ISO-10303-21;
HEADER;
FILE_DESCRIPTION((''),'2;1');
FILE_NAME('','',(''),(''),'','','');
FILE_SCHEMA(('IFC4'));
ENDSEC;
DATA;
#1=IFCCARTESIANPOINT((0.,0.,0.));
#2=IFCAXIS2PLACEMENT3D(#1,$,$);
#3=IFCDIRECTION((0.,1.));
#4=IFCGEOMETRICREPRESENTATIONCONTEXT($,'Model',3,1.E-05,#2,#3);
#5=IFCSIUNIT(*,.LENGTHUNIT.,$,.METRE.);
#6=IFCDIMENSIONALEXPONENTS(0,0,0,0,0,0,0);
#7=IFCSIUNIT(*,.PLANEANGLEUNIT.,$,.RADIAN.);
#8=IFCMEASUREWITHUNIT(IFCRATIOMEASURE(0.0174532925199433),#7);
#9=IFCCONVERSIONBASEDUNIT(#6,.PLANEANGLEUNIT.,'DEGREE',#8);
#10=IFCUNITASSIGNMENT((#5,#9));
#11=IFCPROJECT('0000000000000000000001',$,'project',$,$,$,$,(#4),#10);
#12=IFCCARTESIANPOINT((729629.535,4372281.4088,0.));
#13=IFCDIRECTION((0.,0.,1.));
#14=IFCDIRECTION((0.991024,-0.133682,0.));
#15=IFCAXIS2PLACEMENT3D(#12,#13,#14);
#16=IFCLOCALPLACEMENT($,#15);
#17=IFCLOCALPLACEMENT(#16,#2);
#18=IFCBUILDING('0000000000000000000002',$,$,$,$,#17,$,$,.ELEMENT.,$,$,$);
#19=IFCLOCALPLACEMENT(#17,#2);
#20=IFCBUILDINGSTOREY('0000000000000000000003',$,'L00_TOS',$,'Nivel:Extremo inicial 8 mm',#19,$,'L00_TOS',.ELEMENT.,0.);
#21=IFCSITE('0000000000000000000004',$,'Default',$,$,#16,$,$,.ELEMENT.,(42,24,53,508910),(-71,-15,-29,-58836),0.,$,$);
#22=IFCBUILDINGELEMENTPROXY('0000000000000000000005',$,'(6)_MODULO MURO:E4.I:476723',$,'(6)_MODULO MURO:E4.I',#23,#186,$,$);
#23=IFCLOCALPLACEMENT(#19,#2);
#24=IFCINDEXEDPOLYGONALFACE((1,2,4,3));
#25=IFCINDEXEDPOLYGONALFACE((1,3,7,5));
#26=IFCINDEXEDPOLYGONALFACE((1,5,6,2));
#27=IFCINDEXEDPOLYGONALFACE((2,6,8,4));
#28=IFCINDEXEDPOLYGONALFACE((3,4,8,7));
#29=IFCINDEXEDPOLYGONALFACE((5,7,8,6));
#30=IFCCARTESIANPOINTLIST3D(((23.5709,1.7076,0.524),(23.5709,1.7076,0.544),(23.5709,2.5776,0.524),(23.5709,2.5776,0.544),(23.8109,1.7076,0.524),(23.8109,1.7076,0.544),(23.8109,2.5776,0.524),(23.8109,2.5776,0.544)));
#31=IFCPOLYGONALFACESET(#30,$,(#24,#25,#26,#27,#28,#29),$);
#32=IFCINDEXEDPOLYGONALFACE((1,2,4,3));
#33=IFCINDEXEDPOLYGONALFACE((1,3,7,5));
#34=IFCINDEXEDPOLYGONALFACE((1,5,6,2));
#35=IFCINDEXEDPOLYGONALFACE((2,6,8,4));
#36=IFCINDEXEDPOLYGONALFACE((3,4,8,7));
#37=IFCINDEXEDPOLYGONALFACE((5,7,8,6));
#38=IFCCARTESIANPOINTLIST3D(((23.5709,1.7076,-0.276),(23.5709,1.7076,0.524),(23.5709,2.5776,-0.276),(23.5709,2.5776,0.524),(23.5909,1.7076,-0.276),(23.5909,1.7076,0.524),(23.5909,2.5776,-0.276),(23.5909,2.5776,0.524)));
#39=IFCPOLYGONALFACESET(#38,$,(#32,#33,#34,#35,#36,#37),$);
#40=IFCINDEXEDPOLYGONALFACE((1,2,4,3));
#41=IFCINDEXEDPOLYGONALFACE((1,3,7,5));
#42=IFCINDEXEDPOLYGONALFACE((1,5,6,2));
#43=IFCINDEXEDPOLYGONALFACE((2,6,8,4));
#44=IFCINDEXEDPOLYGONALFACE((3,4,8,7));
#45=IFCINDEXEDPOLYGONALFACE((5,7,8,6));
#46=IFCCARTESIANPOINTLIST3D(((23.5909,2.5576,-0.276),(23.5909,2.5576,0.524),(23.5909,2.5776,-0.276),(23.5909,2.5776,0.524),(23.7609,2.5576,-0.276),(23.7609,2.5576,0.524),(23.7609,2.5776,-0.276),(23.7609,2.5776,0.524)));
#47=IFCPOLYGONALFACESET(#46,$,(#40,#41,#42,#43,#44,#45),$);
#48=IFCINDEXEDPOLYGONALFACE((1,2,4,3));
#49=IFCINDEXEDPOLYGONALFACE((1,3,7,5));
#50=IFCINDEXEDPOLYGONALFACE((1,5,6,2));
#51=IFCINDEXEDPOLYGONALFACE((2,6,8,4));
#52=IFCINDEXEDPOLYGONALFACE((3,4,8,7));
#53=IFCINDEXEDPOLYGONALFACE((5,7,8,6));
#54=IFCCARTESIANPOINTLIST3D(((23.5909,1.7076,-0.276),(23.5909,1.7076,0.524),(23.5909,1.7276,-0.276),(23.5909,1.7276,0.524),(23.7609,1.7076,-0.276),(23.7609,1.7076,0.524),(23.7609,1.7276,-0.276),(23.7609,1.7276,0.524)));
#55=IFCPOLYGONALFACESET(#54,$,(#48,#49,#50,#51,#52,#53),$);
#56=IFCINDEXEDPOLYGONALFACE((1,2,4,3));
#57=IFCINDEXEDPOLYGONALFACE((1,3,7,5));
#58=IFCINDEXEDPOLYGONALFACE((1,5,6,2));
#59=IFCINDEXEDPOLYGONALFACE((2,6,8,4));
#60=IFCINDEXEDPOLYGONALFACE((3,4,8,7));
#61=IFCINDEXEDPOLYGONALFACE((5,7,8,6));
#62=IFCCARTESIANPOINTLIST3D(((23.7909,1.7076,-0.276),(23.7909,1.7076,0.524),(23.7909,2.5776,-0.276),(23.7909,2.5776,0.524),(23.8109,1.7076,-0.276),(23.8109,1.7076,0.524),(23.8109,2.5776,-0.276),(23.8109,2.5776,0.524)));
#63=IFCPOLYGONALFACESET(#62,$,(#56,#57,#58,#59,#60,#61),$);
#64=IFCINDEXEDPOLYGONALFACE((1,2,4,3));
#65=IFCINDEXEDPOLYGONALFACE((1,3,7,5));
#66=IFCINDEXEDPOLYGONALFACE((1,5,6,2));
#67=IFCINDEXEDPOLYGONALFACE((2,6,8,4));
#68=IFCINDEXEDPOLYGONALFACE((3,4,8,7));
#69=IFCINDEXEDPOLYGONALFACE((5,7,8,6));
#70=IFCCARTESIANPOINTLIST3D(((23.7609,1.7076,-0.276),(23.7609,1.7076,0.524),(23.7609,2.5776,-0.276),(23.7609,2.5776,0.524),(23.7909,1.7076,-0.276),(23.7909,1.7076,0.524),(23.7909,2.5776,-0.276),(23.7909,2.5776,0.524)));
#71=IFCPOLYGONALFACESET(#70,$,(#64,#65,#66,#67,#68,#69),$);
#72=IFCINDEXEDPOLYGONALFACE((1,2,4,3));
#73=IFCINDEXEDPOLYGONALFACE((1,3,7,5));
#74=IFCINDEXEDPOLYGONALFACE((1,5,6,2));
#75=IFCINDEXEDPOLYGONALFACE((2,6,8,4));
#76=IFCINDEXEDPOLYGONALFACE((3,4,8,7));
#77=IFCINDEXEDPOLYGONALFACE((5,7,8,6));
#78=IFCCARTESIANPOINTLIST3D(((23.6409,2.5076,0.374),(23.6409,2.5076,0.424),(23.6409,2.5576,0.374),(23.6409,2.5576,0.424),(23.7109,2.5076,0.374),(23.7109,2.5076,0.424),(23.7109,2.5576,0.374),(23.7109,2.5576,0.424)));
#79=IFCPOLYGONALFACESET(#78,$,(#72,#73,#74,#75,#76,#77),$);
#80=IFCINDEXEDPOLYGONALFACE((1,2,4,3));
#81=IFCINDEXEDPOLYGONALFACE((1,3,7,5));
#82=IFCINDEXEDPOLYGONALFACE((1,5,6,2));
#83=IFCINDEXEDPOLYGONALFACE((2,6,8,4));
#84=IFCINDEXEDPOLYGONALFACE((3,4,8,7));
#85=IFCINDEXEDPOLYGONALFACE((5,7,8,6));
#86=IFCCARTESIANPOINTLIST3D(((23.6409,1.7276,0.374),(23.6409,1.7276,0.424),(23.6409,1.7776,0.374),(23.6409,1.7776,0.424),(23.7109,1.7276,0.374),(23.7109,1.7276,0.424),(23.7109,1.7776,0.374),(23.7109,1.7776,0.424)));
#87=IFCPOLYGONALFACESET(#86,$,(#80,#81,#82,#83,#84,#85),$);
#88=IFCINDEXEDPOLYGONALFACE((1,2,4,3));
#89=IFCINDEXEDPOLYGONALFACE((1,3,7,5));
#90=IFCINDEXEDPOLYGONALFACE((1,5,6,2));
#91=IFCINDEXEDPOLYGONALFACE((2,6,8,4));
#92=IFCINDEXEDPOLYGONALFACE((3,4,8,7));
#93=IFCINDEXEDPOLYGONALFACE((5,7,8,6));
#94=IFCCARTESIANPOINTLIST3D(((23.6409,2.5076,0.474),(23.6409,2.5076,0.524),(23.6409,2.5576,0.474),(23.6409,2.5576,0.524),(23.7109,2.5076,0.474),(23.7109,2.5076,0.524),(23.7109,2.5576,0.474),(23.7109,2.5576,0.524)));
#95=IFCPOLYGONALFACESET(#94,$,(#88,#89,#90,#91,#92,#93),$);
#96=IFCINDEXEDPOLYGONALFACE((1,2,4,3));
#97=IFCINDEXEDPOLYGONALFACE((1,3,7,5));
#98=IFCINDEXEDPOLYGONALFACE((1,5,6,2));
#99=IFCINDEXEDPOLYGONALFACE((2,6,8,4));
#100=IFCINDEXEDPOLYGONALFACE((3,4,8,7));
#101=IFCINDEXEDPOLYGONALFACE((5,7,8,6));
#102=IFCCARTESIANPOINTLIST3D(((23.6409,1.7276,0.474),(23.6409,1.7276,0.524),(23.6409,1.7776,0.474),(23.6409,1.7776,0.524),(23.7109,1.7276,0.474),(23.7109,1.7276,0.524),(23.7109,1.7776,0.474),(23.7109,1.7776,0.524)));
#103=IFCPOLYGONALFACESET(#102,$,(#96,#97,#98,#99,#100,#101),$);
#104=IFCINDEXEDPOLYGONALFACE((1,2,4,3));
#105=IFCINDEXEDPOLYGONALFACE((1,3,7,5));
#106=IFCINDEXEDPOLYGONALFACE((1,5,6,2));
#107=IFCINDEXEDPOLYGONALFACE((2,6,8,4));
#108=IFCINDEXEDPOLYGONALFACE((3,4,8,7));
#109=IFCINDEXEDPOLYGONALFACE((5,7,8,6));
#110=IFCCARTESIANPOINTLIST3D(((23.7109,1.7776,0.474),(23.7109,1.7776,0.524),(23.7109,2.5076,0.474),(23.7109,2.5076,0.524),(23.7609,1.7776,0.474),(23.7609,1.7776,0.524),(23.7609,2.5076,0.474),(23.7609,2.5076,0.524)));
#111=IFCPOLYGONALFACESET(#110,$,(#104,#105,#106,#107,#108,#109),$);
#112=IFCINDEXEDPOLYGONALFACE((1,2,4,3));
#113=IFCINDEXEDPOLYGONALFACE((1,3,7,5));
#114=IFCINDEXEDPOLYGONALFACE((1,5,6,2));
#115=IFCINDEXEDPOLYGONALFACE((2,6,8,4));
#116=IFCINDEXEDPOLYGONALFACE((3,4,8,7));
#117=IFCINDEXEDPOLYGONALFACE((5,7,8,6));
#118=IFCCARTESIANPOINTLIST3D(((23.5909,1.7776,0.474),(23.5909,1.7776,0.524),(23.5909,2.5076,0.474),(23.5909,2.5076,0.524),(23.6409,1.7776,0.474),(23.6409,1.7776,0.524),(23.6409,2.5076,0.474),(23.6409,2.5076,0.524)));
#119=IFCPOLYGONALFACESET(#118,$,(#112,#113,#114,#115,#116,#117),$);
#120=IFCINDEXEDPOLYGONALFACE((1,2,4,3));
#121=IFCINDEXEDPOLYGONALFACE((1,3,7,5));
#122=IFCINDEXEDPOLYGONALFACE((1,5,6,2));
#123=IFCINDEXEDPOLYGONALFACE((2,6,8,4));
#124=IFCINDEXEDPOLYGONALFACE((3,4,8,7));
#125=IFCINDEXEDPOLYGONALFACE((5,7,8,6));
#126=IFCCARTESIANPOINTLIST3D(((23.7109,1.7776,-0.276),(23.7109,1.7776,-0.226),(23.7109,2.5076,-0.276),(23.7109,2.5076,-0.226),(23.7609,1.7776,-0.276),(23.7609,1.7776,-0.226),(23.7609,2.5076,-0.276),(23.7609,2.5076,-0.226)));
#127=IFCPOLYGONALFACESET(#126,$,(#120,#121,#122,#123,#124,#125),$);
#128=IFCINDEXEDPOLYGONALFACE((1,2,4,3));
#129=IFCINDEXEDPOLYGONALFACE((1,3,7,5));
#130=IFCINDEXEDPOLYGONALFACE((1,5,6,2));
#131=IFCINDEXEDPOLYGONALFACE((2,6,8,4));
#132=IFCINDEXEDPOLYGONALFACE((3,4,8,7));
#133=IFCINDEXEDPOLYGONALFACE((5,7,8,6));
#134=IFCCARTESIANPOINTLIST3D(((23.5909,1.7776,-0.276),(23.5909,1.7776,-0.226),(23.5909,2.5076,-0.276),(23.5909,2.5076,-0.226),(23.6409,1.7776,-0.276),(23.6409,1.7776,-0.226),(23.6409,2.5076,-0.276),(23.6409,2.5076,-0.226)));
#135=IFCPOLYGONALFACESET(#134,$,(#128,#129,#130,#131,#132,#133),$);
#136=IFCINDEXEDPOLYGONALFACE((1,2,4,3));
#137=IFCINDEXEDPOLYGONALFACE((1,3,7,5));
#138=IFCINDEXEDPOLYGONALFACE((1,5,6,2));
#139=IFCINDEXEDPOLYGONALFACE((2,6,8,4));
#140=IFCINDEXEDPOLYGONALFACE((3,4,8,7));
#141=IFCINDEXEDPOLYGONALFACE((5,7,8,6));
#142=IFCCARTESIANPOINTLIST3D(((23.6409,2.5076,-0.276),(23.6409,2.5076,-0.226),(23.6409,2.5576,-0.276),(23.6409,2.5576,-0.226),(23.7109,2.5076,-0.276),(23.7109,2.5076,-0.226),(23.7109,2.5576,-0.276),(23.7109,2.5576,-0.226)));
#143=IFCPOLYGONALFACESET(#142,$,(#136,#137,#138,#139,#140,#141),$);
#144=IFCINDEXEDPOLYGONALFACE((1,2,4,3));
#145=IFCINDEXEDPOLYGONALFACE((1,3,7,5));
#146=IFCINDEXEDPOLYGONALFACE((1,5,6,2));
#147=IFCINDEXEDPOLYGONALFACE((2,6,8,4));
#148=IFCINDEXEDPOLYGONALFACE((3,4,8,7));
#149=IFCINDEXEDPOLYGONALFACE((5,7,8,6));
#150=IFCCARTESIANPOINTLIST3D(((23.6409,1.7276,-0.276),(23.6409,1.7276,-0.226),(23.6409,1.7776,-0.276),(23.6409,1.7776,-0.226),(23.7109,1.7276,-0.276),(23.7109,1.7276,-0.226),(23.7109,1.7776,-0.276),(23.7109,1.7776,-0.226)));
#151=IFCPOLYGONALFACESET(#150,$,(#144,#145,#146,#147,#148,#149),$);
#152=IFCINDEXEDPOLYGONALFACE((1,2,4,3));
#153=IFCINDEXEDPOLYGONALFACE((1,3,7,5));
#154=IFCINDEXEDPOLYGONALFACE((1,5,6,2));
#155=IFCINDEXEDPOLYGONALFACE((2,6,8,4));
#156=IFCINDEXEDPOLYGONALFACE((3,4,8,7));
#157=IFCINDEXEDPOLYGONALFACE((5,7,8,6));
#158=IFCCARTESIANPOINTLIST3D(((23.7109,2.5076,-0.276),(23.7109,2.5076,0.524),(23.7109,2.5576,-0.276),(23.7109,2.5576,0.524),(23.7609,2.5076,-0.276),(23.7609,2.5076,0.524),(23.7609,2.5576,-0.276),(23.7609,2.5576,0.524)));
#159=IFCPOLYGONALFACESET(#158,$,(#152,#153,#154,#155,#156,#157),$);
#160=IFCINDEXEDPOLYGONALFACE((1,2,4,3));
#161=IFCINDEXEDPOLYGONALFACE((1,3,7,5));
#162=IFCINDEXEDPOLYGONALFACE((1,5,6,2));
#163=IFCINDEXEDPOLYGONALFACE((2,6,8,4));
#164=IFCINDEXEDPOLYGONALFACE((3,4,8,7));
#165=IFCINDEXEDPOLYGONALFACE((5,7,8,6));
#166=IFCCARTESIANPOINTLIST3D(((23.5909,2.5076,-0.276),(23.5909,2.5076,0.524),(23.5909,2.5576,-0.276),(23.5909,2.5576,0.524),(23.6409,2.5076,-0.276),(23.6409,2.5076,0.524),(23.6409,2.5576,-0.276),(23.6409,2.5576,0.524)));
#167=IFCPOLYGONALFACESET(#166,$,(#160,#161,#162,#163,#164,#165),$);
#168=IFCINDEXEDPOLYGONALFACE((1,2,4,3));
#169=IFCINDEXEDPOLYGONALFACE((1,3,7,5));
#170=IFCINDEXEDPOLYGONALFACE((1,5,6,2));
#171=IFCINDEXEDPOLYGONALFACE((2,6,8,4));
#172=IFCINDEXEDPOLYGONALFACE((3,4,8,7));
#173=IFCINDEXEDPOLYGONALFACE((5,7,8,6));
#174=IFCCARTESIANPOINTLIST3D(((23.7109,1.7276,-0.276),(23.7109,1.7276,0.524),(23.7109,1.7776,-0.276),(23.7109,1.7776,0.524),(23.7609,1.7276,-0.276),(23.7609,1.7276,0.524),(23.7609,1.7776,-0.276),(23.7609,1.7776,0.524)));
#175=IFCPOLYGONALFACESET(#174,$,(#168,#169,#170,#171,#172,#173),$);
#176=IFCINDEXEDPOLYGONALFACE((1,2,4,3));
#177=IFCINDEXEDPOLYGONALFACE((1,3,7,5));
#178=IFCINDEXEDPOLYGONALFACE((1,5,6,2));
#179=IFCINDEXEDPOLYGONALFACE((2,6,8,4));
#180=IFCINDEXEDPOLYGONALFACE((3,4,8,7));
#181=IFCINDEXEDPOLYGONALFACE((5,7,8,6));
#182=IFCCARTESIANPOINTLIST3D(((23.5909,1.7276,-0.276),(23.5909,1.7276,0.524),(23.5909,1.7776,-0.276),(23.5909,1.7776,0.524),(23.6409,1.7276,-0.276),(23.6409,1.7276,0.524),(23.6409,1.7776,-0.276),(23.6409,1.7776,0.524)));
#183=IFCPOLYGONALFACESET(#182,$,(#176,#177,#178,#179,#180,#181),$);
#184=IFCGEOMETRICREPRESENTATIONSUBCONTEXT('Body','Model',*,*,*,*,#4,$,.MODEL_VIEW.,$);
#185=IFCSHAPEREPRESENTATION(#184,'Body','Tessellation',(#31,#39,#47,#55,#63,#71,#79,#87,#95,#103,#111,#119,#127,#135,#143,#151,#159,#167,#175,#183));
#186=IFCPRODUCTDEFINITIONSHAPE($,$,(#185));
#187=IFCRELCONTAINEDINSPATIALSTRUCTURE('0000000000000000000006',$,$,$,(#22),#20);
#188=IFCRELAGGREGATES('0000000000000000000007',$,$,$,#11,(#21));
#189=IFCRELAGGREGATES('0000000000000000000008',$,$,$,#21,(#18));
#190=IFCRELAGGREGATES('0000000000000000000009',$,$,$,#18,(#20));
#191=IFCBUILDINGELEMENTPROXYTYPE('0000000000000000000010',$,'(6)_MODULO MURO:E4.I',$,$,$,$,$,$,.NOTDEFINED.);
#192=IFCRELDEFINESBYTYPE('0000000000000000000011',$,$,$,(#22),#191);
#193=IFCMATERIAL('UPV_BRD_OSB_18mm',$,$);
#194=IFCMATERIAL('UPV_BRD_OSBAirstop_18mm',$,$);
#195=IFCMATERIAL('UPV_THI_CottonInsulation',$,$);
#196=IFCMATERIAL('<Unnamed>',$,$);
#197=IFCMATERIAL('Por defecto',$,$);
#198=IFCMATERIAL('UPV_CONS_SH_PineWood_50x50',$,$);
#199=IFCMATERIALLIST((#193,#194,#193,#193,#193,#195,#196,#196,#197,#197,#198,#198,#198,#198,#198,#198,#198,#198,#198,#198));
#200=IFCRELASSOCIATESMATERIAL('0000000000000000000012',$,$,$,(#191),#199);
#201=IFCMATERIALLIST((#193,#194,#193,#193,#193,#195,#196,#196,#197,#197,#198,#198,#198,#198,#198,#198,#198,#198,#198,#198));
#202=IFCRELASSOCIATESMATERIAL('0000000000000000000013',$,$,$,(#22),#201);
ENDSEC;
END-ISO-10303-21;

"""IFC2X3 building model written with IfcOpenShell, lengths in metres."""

from ifc_helpers import new_model, entity, si_unit, converted_unit, direction, frame, frame_2d, origin, origin_2d_with_axis, place, context, subcontext, project, spatial, rectangle, extrude, source, transform, mapped, material, material_list, type_object, type_shapes, element, save


model = new_model("IFC2X3")

# Units and contexts
model_context = context("Model", 3, precision=1e-05, world=origin(), true_north=direction((0.0, 1.0)))
body_context = subcontext(model_context, "Body", "Model", "MODEL_VIEW")
ifc_project = project(units=[si_unit("LENGTHUNIT", "METRE"), converted_unit("PLANEANGLEUNIT", "DEGREE", entity("IfcRatioMeasure", 0.0174532925199433), si_unit("PLANEANGLEUNIT", "RADIAN"), dimensions=[0, 0, 0, 0, 0, 0, 0])], contexts=[model_context])

# Site, building, storey
site_placement = place(None, frame((729629.535, 4372281.4088, 0.0), z_axis=(0.0, 0.0, 1.0), x_axis=(0.991024, -0.133682, 0.0)))
site = spatial("IfcSite", under=ifc_project, at=site_placement, Name="Default", CompositionType="ELEMENT", RefLatitude=(42, 24, 53, 508910), RefLongitude=(-71, -15, -29, -58836), RefElevation=0.0)
building_placement = place(site_placement, origin())
building = spatial("IfcBuilding", under=site, at=building_placement, CompositionType="ELEMENT")
storey_placement = place(building_placement, origin())
storey = spatial("IfcBuildingStorey", under=building, at=storey_placement, Name="L00_TOS", ObjectType="Nivel:Extremo inicial 8 mm", LongName="L00_TOS", CompositionType="ELEMENT", Elevation=0.0)

# Building element proxy
ifc_material_1 = material(Name="UPV_BRD_OSBAirstop_18mm")
ifc_material_2 = material(Name="UPV_BRD_OSB_18mm")
ifc_material_3 = material(Name="UPV_THI_CottonInsulation")
ifc_material_4 = material(Name="<Unnamed>")
ifc_material_5 = material(Name="UPV_CONS_SH_PineWood_50x50")
ifc_material_6 = material(Name="Por defecto")
ifc_material_list_1 = material_list([ifc_material_2, ifc_material_1, ifc_material_2, ifc_material_2, ifc_material_2, ifc_material_3, ifc_material_4, ifc_material_4, ifc_material_6, ifc_material_6, ifc_material_5, ifc_material_5, ifc_material_5, ifc_material_5, ifc_material_5, ifc_material_5, ifc_material_5, ifc_material_5, ifc_material_5, ifc_material_5])
ifc_material_list_2 = material_list([ifc_material_2, ifc_material_1, ifc_material_2, ifc_material_2, ifc_material_2, ifc_material_3, ifc_material_4, ifc_material_4, ifc_material_6, ifc_material_6, ifc_material_5, ifc_material_5, ifc_material_5, ifc_material_5, ifc_material_5, ifc_material_5, ifc_material_5, ifc_material_5, ifc_material_5, ifc_material_5])
building_element_proxy_type_1 = type_object("IfcBuildingElementProxyType", Name="(6)_MODULO MURO:E4.I", PredefinedType="NOTDEFINED", material=ifc_material_list_2)
shared_shape_1 = source(origin(), body_context, "Body", "SweptSolid", [
    extrude(rectangle(XDim=0.87, YDim=0.24, at=origin_2d_with_axis()), frame((0.0, 0.015, 0.8), z_axis=(0.0, 0.0, 1.0), x_axis=(-1.0, 0.0, 0.0)), (0.0, 0.0, 1.0), 0.02),
    extrude(rectangle(XDim=0.87, YDim=0.02, at=origin_2d_with_axis()), frame((0.0, -0.095, 0.0)), (0.0, 0.0, 1.0), 0.8),
    extrude(rectangle(XDim=0.17, YDim=0.02, at=frame_2d((0.0, 0.0), x_axis=(1.0, 0.0))), frame((-0.425, 0.0, 0.0), z_axis=(0.0, 0.0, 1.0), x_axis=(0.0, -1.0, 0.0)), (0.0, 0.0, 1.0), 0.8),
    extrude(rectangle(XDim=0.17, YDim=0.02, at=origin_2d_with_axis()), frame((0.425, 0.0, 0.0), z_axis=(0.0, 0.0, 1.0), x_axis=(0.0, -1.0, 0.0)), (0.0, 0.0, 1.0), 0.8),
    extrude(rectangle(XDim=0.87, YDim=0.02, at=origin_2d_with_axis()), frame((0.0, 0.125, 0.0), z_axis=(0.0, 0.0, 1.0), x_axis=(-1.0, 0.0, 0.0)), (0.0, 0.0, 1.0), 0.8),
    extrude(rectangle(XDim=0.87, YDim=0.03, at=origin_2d_with_axis()), frame((0.0, 0.1, 0.0), z_axis=(0.0, 0.0, 1.0), x_axis=(-1.0, 0.0, 0.0)), (0.0, 0.0, 1.0), 0.8),
    extrude(rectangle(XDim=0.07, YDim=0.05, at=origin_2d_with_axis()), frame((-0.39, 0.0, 0.65), z_axis=(0.0, 0.0, 1.0), x_axis=(0.0, 1.0, 0.0)), (0.0, 0.0, 1.0), 0.05),
    extrude(rectangle(XDim=0.07, YDim=0.05, at=origin_2d_with_axis()), frame((0.39, 0.0, 0.65), z_axis=(0.0, 0.0, 1.0), x_axis=(0.0, 1.0, 0.0)), (0.0, 0.0, 1.0), 0.05),
    extrude(rectangle(XDim=0.07, YDim=0.05, at=origin_2d_with_axis()), frame((-0.39, 0.0, 0.75), z_axis=(0.0, 0.0, 1.0), x_axis=(0.0, -1.0, 0.0)), (0.0, 0.0, 1.0), 0.05),
    extrude(rectangle(XDim=0.07, YDim=0.05, at=frame_2d((0.0, 0.0), x_axis=(1.0, 0.0))), frame((0.39, 0.0, 0.75), z_axis=(0.0, 0.0, 1.0), x_axis=(0.0, -1.0, 0.0)), (0.0, 0.0, 1.0), 0.05),
    extrude(rectangle(XDim=0.73, YDim=0.05, at=origin_2d_with_axis()), frame((0.0, 0.06, 0.75), z_axis=(0.0, 0.0, 1.0), x_axis=(-1.0, 0.0, 0.0)), (0.0, 0.0, 1.0), 0.05),
    extrude(rectangle(XDim=0.05, YDim=0.73, at=origin_2d_with_axis()), frame((0.0, -0.06, 0.75), z_axis=(0.0, 0.0, 1.0), x_axis=(0.0, -1.0, 0.0)), (0.0, 0.0, 1.0), 0.05),
    extrude(rectangle(XDim=0.05, YDim=0.73, at=origin_2d_with_axis()), frame((0.0, 0.06, 0.0), z_axis=(0.0, 0.0, 1.0), x_axis=(0.0, -1.0, 0.0)), (0.0, 0.0, 1.0), 0.05),
    extrude(rectangle(XDim=0.05, YDim=0.73, at=origin_2d_with_axis()), frame((0.0, -0.06, 0.0), z_axis=(0.0, 0.0, 1.0), x_axis=(0.0, -1.0, 0.0)), (0.0, 0.0, 1.0), 0.05),
    extrude(rectangle(XDim=0.07, YDim=0.05, at=origin_2d_with_axis()), frame((-0.39, 0.0, 0.0), z_axis=(0.0, 0.0, 1.0), x_axis=(0.0, -1.0, 0.0)), (0.0, 0.0, 1.0), 0.05),
    extrude(rectangle(XDim=0.05, YDim=0.07, at=origin_2d_with_axis()), frame((0.39, 0.0, 0.0), z_axis=(0.0, 0.0, 1.0), x_axis=(-1.0, 0.0, 0.0)), (0.0, 0.0, 1.0), 0.05),
    extrude(rectangle(XDim=0.05, YDim=0.05, at=origin_2d_with_axis()), frame((-0.39, 0.06, 0.0), z_axis=(0.0, 0.0, 1.0), x_axis=(0.0, -1.0, 0.0)), (0.0, 0.0, 1.0), 0.8),
    extrude(rectangle(XDim=0.05, YDim=0.05, at=origin_2d_with_axis()), frame((-0.39, -0.06, 0.0), z_axis=(0.0, 0.0, 1.0), x_axis=(0.0, -1.0, 0.0)), (0.0, 0.0, 1.0), 0.8),
    extrude(rectangle(XDim=0.05, YDim=0.05, at=origin_2d_with_axis()), frame((0.39, 0.06, 0.0), z_axis=(0.0, 0.0, 1.0), x_axis=(0.0, -1.0, 0.0)), (0.0, 0.0, 1.0), 0.8),
    extrude(rectangle(XDim=0.05, YDim=0.05, at=origin_2d_with_axis()), frame((0.39, -0.06, 0.0), z_axis=(0.0, 0.0, 1.0), x_axis=(0.0, -1.0, 0.0)), (0.0, 0.0, 1.0), 0.8),
])
type_shapes(building_element_proxy_type_1, [shared_shape_1])
proxy_1_placement = place(storey_placement, frame((23.6759, 2.1426, -0.276), z_axis=(0.0, 0.0, 1.0), x_axis=(0.0, -1.0, 0.0)))
element("IfcBuildingElementProxy", 1, at=proxy_1_placement, inside=storey, type_object=building_element_proxy_type_1, material=ifc_material_list_1, Name="(6)_MODULO MURO:E4.I:476723", ObjectType="(6)_MODULO MURO:E4.I", context=body_context, shape_type="MappedRepresentation", body=[
    mapped(shared_shape_1, transform((0.0, 0.0, 0.0), scale=1.0)),
])

save(model, "model.ifc")
